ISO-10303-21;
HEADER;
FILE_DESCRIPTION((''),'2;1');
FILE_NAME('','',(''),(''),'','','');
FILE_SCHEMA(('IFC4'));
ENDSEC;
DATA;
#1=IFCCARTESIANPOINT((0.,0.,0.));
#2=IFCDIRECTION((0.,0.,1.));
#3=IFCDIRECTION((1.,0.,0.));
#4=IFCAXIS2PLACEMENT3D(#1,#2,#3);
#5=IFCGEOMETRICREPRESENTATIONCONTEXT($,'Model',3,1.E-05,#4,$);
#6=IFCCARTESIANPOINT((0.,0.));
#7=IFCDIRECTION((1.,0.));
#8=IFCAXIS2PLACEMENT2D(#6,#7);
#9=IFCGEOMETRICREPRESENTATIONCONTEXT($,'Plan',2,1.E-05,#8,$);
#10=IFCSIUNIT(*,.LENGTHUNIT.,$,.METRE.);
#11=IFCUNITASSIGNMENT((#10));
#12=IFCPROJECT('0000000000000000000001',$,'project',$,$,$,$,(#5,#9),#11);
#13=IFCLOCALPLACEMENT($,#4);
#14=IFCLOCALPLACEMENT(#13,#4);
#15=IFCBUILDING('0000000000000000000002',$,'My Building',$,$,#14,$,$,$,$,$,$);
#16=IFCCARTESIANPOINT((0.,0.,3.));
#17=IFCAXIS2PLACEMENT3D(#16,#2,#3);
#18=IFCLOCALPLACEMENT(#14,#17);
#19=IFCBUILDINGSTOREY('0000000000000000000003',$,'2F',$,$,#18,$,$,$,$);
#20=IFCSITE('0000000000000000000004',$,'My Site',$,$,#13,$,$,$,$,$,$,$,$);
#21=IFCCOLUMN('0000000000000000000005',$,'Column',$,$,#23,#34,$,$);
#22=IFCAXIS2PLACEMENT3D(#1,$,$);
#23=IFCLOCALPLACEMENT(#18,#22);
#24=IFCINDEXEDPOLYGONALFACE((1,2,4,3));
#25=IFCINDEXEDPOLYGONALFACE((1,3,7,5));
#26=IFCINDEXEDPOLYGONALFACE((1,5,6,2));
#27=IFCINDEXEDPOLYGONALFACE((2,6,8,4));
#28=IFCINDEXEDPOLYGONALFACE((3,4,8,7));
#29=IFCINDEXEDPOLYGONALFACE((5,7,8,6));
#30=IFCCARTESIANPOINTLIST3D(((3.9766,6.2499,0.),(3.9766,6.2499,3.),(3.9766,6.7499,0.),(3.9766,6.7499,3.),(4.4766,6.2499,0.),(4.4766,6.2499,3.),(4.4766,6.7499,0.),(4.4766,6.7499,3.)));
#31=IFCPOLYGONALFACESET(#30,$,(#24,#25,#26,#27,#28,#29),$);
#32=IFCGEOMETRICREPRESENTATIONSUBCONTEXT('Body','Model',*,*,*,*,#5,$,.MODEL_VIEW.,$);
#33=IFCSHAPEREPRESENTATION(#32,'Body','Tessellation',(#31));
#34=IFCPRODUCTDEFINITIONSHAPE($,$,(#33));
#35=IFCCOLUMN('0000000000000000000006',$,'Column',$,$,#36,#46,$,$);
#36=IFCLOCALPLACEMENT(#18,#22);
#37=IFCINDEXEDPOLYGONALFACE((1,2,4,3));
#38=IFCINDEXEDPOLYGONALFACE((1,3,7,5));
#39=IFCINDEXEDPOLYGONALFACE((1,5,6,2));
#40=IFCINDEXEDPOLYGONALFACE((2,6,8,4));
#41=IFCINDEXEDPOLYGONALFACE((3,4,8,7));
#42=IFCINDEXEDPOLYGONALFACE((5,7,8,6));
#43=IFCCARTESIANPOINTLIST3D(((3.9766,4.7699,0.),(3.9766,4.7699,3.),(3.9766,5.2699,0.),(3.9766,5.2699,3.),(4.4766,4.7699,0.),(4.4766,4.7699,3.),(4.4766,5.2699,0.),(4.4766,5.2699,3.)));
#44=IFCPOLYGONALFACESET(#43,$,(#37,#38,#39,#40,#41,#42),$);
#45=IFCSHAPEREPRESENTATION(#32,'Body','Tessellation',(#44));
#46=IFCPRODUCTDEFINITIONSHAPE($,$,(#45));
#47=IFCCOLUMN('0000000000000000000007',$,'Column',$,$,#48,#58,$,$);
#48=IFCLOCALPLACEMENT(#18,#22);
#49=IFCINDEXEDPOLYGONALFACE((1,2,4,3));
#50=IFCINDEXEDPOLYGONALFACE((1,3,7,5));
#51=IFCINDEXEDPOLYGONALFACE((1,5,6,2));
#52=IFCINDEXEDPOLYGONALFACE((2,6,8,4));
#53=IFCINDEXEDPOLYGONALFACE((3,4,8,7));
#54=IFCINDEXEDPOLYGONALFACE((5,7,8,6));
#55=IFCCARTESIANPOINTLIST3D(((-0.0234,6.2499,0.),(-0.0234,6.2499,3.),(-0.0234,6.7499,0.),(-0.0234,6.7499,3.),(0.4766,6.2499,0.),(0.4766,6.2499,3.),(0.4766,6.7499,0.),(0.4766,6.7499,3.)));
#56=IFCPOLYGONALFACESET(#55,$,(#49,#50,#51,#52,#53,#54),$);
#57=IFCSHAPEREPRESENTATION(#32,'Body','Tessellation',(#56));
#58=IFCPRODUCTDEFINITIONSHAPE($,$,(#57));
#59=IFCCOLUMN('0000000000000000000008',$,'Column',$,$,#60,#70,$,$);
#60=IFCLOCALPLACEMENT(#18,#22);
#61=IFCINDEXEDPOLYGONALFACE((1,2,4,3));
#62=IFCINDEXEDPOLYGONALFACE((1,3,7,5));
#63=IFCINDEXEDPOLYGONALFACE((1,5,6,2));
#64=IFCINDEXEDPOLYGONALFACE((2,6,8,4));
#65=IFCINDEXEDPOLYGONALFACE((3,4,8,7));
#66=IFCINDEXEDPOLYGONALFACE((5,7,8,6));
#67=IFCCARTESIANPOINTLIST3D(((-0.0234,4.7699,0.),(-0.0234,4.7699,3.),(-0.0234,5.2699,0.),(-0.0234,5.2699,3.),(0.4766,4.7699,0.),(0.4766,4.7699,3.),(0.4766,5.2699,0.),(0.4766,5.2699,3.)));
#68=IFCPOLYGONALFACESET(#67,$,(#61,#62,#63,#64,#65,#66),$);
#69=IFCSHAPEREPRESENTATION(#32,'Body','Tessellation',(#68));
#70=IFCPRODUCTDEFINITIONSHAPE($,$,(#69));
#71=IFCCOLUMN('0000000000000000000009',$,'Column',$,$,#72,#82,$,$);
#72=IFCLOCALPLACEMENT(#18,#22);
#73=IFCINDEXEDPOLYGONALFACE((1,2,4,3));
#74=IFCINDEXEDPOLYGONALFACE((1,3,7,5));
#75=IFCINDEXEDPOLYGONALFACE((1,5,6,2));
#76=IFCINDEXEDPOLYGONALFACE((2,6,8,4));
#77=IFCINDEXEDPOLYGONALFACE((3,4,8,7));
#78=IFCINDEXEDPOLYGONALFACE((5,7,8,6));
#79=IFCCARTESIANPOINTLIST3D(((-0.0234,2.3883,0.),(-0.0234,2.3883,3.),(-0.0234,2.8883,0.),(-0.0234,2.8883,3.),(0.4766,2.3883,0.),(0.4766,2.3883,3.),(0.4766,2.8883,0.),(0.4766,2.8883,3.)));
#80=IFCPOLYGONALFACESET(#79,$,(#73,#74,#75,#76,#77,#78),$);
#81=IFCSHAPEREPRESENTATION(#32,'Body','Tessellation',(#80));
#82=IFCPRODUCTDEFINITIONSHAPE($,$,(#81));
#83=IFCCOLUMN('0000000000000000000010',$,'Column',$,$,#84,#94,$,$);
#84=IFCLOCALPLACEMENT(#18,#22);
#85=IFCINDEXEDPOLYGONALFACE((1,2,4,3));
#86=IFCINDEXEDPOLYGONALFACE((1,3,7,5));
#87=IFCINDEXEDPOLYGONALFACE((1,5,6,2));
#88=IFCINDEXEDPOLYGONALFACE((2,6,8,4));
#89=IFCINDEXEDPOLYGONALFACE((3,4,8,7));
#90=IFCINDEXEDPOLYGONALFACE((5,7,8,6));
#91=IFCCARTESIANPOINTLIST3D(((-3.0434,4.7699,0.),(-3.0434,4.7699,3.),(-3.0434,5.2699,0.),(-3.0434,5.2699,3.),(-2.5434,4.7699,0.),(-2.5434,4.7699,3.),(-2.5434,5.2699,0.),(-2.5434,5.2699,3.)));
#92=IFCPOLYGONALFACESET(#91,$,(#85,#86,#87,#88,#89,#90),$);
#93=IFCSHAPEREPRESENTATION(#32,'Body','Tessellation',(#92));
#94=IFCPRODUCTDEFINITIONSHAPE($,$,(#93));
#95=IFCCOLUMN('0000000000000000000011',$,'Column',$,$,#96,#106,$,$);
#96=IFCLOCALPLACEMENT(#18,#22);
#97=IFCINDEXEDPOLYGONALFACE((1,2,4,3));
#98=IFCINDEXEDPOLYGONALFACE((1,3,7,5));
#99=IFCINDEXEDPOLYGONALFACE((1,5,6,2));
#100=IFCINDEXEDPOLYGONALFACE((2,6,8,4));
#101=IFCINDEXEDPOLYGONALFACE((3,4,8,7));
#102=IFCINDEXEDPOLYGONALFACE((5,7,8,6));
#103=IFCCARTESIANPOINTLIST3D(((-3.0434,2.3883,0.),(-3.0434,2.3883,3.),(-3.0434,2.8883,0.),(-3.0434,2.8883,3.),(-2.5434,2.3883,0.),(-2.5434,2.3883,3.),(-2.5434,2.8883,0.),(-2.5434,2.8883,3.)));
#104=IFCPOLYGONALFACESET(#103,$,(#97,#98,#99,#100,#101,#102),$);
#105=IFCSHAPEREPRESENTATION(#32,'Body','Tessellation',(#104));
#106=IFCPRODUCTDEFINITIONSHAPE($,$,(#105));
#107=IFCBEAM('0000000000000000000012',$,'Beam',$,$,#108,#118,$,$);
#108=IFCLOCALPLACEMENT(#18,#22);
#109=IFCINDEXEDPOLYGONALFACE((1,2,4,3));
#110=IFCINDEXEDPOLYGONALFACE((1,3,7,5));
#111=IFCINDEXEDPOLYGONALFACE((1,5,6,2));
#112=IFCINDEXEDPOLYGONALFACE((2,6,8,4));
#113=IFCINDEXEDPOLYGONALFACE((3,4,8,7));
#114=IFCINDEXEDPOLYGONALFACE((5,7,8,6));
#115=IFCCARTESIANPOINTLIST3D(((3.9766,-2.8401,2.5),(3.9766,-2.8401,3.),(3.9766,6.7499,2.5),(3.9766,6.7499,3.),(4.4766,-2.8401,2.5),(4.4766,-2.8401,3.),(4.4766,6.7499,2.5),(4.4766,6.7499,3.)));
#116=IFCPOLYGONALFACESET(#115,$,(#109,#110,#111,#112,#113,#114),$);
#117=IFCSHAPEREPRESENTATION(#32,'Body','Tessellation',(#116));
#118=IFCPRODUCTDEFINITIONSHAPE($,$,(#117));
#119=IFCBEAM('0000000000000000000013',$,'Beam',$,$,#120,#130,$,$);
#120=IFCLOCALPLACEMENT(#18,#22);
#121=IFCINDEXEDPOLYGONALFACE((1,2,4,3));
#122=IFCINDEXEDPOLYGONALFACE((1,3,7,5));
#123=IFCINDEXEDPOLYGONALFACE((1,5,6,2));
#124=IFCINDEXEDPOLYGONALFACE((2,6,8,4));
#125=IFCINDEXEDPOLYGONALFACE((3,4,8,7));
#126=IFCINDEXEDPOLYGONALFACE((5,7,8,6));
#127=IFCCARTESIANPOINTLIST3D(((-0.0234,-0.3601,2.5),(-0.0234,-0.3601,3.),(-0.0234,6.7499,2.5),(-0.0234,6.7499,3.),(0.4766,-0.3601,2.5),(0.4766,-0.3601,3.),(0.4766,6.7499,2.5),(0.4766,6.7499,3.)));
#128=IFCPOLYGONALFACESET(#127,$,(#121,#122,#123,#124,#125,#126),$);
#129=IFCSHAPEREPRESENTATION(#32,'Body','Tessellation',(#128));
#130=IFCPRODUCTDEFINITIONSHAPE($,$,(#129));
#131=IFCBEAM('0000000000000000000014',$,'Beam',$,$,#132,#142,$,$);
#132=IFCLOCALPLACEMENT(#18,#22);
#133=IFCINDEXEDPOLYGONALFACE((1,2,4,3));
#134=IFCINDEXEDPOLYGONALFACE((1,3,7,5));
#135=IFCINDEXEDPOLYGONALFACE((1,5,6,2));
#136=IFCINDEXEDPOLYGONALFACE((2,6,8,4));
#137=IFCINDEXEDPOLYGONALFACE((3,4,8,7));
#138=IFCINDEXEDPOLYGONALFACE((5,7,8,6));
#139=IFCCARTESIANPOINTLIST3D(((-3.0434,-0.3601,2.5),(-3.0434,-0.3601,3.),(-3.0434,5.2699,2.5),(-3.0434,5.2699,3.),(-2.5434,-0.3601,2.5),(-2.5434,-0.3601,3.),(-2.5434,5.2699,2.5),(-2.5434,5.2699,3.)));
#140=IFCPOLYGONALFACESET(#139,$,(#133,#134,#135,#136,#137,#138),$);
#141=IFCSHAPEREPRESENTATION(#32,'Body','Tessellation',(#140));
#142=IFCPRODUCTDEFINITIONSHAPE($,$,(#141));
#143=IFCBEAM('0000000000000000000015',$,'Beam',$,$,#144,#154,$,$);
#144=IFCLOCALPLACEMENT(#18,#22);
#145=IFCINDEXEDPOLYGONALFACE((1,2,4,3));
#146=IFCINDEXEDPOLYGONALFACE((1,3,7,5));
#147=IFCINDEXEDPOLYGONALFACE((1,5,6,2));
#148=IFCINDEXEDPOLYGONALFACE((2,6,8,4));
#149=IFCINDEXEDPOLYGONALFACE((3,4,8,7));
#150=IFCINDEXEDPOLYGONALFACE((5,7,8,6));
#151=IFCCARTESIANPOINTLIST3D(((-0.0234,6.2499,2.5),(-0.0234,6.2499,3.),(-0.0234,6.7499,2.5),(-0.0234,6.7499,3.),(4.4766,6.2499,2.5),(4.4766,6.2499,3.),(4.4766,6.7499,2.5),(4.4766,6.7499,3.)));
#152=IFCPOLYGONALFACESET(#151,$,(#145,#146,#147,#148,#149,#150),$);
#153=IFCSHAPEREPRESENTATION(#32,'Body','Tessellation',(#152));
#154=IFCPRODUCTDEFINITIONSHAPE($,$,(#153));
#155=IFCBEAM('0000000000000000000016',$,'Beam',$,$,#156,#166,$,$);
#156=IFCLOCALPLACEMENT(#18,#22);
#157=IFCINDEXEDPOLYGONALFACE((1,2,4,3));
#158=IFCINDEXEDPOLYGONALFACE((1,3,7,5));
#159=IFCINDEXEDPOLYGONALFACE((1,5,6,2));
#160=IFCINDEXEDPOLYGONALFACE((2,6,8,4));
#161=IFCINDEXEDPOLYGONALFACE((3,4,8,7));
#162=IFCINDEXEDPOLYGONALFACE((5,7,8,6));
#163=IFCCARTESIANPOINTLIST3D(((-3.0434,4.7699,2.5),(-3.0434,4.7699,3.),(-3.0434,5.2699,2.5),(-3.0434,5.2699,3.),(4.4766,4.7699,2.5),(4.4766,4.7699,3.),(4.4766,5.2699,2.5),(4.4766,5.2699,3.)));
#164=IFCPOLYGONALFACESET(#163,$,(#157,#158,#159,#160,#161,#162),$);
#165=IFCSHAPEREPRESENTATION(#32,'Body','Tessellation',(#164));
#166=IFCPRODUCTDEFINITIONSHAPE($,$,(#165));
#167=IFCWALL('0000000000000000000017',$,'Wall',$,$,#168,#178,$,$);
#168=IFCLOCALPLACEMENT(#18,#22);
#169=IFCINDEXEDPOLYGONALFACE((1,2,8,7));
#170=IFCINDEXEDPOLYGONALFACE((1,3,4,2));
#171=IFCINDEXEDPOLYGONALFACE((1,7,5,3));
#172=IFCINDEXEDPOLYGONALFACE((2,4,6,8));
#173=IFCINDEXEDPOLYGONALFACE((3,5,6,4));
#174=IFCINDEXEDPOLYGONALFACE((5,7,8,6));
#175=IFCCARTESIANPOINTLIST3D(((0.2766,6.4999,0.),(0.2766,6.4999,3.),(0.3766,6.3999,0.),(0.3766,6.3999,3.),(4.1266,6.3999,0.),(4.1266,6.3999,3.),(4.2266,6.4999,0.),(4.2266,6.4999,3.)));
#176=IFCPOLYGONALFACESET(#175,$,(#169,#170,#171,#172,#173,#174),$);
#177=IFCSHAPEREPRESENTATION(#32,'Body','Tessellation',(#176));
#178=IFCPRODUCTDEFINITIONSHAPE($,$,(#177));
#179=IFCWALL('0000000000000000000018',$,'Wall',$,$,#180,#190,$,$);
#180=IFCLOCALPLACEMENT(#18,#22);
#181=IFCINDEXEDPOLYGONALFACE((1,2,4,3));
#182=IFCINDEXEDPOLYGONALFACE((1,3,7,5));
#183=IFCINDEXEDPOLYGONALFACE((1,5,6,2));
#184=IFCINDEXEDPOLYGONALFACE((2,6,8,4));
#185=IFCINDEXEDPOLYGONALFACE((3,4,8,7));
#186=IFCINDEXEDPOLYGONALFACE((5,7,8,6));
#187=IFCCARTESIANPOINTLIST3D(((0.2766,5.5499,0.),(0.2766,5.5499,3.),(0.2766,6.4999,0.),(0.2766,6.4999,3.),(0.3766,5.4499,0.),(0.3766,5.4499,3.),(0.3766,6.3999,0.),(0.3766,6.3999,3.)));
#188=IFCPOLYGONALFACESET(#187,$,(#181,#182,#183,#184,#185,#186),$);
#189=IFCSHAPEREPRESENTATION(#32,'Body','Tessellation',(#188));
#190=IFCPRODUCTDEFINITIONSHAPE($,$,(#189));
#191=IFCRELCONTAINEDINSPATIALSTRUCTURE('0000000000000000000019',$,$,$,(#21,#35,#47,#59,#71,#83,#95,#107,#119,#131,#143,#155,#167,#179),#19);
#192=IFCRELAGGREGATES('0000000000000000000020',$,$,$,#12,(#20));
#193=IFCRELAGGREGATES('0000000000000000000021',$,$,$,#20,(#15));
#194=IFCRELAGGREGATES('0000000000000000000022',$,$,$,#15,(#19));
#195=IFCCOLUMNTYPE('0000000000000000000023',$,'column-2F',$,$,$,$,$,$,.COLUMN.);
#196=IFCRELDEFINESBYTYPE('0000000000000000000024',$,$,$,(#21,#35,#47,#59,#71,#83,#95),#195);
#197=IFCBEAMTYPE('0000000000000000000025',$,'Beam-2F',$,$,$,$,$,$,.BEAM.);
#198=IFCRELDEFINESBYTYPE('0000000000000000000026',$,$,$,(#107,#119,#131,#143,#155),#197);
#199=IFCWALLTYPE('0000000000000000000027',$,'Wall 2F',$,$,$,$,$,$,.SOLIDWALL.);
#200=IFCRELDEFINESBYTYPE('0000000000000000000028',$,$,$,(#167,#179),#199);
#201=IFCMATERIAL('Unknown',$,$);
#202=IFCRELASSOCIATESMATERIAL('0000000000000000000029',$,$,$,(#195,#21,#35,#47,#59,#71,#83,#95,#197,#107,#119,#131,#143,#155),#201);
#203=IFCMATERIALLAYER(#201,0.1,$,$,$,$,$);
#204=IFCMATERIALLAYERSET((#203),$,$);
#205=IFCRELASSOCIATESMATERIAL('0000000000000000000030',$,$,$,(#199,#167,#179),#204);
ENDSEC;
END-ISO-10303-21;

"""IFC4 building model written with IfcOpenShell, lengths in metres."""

from ifc_helpers import new_model, si_unit, frame, origin_with_axes, origin_2d_with_axis, place, context, subcontext, project, spatial, line, indexed_curve, rectangle, outline, extrude, material, layer, layer_set, layer_usage, material_profile, profile_set, profile_usage, type_object, element, save


model = new_model("IFC4")

# Units and contexts
model_context = context("Model", 3, precision=1e-05, world=origin_with_axes())
plan_context = context("Plan", 2, precision=1e-05, world=origin_2d_with_axis())
body_context_1 = subcontext(model_context, "Body", "Model", "MODEL_VIEW")
ifc_project = project(units=[si_unit("LENGTHUNIT", "METRE")], contexts=[model_context, plan_context])

# Site, building, storey
site_placement = place(None, origin_with_axes())
site = spatial("IfcSite", under=ifc_project, at=site_placement, Name="My Site")
building_placement = place(site_placement, origin_with_axes())
building = spatial("IfcBuilding", under=site, at=building_placement, Name="My Building")
storey_placement = place(building_placement, frame((0.0, 0.0, 3.0), z_axis=(0.0, 0.0, 1.0), x_axis=(1.0, 0.0, 0.0)))
storey = spatial("IfcBuildingStorey", under=building, at=storey_placement, Name="2F")

# Columns
ifc_material = material(Name="Unknown")
ifc_material_profile_1 = material_profile(ifc_material, rectangle(XDim=0.5, YDim=0.5))
ifc_profile_set_1 = profile_set([ifc_material_profile_1])
ifc_profile_usage_1 = profile_usage(ifc_profile_set_1, cardinal=7)
column_type = type_object("IfcColumnType", Name="column-2F", PredefinedType="COLUMN", material=ifc_profile_set_1)
column_1_placement = place(storey_placement, frame((4.4766, 6.7499, 0.0), z_axis=(0.0, 0.0, 1.0), x_axis=(1.0, 0.0, 0.0)))
element("IfcColumn", 1, at=column_1_placement, inside=storey, type_object=column_type, material=ifc_profile_usage_1, Name="Column", context=body_context_1, shape_type="SweptSolid", body=[
    extrude(rectangle(XDim=0.5, YDim=0.5), frame((-0.25, -0.25, 0.0), z_axis=(0.0, 0.0, 1.0), x_axis=(1.0, 0.0, 0.0)), (0.0, 0.0, 1.0), 3.0),
])
ifc_profile_usage_2 = profile_usage(ifc_profile_set_1, cardinal=7)
column_2_placement = place(storey_placement, frame((4.4766, 5.2699, 0.0), z_axis=(0.0, 0.0, 1.0), x_axis=(1.0, 0.0, 0.0)))
element("IfcColumn", 2, at=column_2_placement, inside=storey, type_object=column_type, material=ifc_profile_usage_2, Name="Column", context=body_context_1, shape_type="SweptSolid", body=[
    extrude(rectangle(XDim=0.5, YDim=0.5), frame((-0.25, -0.25, 0.0), z_axis=(0.0, 0.0, 1.0), x_axis=(1.0, 0.0, 0.0)), (0.0, 0.0, 1.0), 3.0),
])
ifc_profile_usage_3 = profile_usage(ifc_profile_set_1, cardinal=7)
column_3_placement = place(storey_placement, frame((0.4766, 6.7499, 0.0), z_axis=(0.0, 0.0, 1.0), x_axis=(1.0, 0.0, 0.0)))
element("IfcColumn", 3, at=column_3_placement, inside=storey, type_object=column_type, material=ifc_profile_usage_3, Name="Column", context=body_context_1, shape_type="SweptSolid", body=[
    extrude(rectangle(XDim=0.5, YDim=0.5), frame((-0.25, -0.25, 0.0), z_axis=(0.0, 0.0, 1.0), x_axis=(1.0, 0.0, 0.0)), (0.0, 0.0, 1.0), 3.0),
])
ifc_profile_usage_4 = profile_usage(ifc_profile_set_1, cardinal=7)
column_4_placement = place(storey_placement, frame((0.4766, 5.2699, 0.0), z_axis=(0.0, 0.0, 1.0), x_axis=(1.0, 0.0, 0.0)))
element("IfcColumn", 4, at=column_4_placement, inside=storey, type_object=column_type, material=ifc_profile_usage_4, Name="Column", context=body_context_1, shape_type="SweptSolid", body=[
    extrude(rectangle(XDim=0.5, YDim=0.5), frame((-0.25, -0.25, 0.0), z_axis=(0.0, 0.0, 1.0), x_axis=(1.0, 0.0, 0.0)), (0.0, 0.0, 1.0), 3.0),
])
ifc_profile_usage_5 = profile_usage(ifc_profile_set_1, cardinal=7)
column_5_placement = place(storey_placement, frame((0.4766, 2.8883, 0.0), z_axis=(0.0, 0.0, 1.0), x_axis=(1.0, 0.0, 0.0)))
element("IfcColumn", 5, at=column_5_placement, inside=storey, type_object=column_type, material=ifc_profile_usage_5, Name="Column", context=body_context_1, shape_type="SweptSolid", body=[
    extrude(rectangle(XDim=0.5, YDim=0.5), frame((-0.25, -0.25, 0.0), z_axis=(0.0, 0.0, 1.0), x_axis=(1.0, 0.0, 0.0)), (0.0, 0.0, 1.0), 3.0),
])
ifc_profile_usage_6 = profile_usage(ifc_profile_set_1, cardinal=7)
column_6_placement = place(storey_placement, frame((-2.5434, 5.2699, 0.0), z_axis=(0.0, 0.0, 1.0), x_axis=(1.0, 0.0, 0.0)))
element("IfcColumn", 6, at=column_6_placement, inside=storey, type_object=column_type, material=ifc_profile_usage_6, Name="Column", context=body_context_1, shape_type="SweptSolid", body=[
    extrude(rectangle(XDim=0.5, YDim=0.5), frame((-0.25, -0.25, 0.0), z_axis=(0.0, 0.0, 1.0), x_axis=(1.0, 0.0, 0.0)), (0.0, 0.0, 1.0), 3.0),
])
ifc_profile_usage_7 = profile_usage(ifc_profile_set_1, cardinal=7)
column_7_placement = place(storey_placement, frame((-2.5434, 2.8883, 0.0), z_axis=(0.0, 0.0, 1.0), x_axis=(1.0, 0.0, 0.0)))
element("IfcColumn", 7, at=column_7_placement, inside=storey, type_object=column_type, material=ifc_profile_usage_7, Name="Column", context=body_context_1, shape_type="SweptSolid", body=[
    extrude(rectangle(XDim=0.5, YDim=0.5), frame((-0.25, -0.25, 0.0), z_axis=(0.0, 0.0, 1.0), x_axis=(1.0, 0.0, 0.0)), (0.0, 0.0, 1.0), 3.0),
])

# Beams
ifc_material_profile_2 = material_profile(ifc_material, rectangle(XDim=0.5, YDim=0.5))
ifc_profile_set_2 = profile_set([ifc_material_profile_2])
ifc_profile_usage_8 = profile_usage(ifc_profile_set_2, cardinal=7)
beam_type = type_object("IfcBeamType", Name="Beam-2F", PredefinedType="BEAM", material=ifc_profile_set_2)
beam_1_placement = place(storey_placement, frame((4.4766, 6.7499, 3.0), z_axis=(0.0, -1.0, 0.0), x_axis=(1.0, 0.0, 0.0)))
element("IfcBeam", 8, at=beam_1_placement, inside=storey, type_object=beam_type, material=ifc_profile_usage_8, Name="Beam", context=body_context_1, shape_type="SweptSolid", body=[
    extrude(rectangle(XDim=0.5, YDim=0.5), frame((-0.25, -0.25, 0.0), z_axis=(0.0, 0.0, 1.0), x_axis=(1.0, 0.0, 0.0)), (0.0, 0.0, 1.0), 9.59),
])
ifc_profile_usage_9 = profile_usage(ifc_profile_set_2, cardinal=7)
beam_2_placement = place(storey_placement, frame((0.4766, 6.7499, 3.0), z_axis=(0.0, -1.0, 0.0), x_axis=(1.0, 0.0, 0.0)))
element("IfcBeam", 9, at=beam_2_placement, inside=storey, type_object=beam_type, material=ifc_profile_usage_9, Name="Beam", context=body_context_1, shape_type="SweptSolid", body=[
    extrude(rectangle(XDim=0.5, YDim=0.5), frame((-0.25, -0.25, 0.0), z_axis=(0.0, 0.0, 1.0), x_axis=(1.0, 0.0, 0.0)), (0.0, 0.0, 1.0), 7.11),
])
ifc_profile_usage_10 = profile_usage(ifc_profile_set_2, cardinal=7)
beam_3_placement = place(storey_placement, frame((-2.5434, 5.2699, 3.0), z_axis=(0.0, -1.0, 0.0), x_axis=(1.0, 0.0, 0.0)))
element("IfcBeam", 10, at=beam_3_placement, inside=storey, type_object=beam_type, material=ifc_profile_usage_10, Name="Beam", context=body_context_1, shape_type="SweptSolid", body=[
    extrude(rectangle(XDim=0.5, YDim=0.5), frame((-0.25, -0.25, 0.0), z_axis=(0.0, 0.0, 1.0), x_axis=(1.0, 0.0, 0.0)), (0.0, 0.0, 1.0), 5.63),
])
ifc_profile_usage_11 = profile_usage(ifc_profile_set_2, cardinal=7)
beam_4_placement = place(storey_placement, frame((4.4766, 6.2499, 3.0), z_axis=(-1.0, 0.0, 0.0), x_axis=(0.0, -1.0, 0.0)))
element("IfcBeam", 11, at=beam_4_placement, inside=storey, type_object=beam_type, material=ifc_profile_usage_11, Name="Beam", context=body_context_1, shape_type="SweptSolid", body=[
    extrude(rectangle(XDim=0.5, YDim=0.5), frame((-0.25, -0.25, 0.0), z_axis=(0.0, 0.0, 1.0), x_axis=(1.0, 0.0, 0.0)), (0.0, 0.0, 1.0), 4.5),
])
ifc_profile_usage_12 = profile_usage(ifc_profile_set_2, cardinal=7)
beam_5_placement = place(storey_placement, frame((4.4766, 4.7699, 3.0), z_axis=(-1.0, 0.0, 0.0), x_axis=(0.0, -1.0, 0.0)))
element("IfcBeam", 12, at=beam_5_placement, inside=storey, type_object=beam_type, material=ifc_profile_usage_12, Name="Beam", context=body_context_1, shape_type="SweptSolid", body=[
    extrude(rectangle(XDim=0.5, YDim=0.5), frame((-0.25, -0.25, 0.0), z_axis=(0.0, 0.0, 1.0), x_axis=(1.0, 0.0, 0.0)), (0.0, 0.0, 1.0), 7.52),
])

# Walls
ifc_layer = layer(ifc_material, 0.1)
ifc_layer_set = layer_set([ifc_layer])
ifc_layer_usage_1 = layer_usage(ifc_layer_set, "AXIS2", "POSITIVE", 0.0)
wall_type = type_object("IfcWallType", Name="Wall 2F", PredefinedType="SOLIDWALL", material=ifc_layer_set)
wall_1_placement = place(storey_placement, frame((4.2266, 6.4999, 0.0), z_axis=(0.0, 0.0, 1.0), x_axis=(-1.0, 0.0, 0.0)))
element("IfcWall", 13, at=wall_1_placement, inside=storey, type_object=wall_type, material=ifc_layer_usage_1, Name="Wall", context=body_context_1, shape_type="SweptSolid", body=[
    extrude(outline(indexed_curve([(0.0, 0.0), (0.1, 0.1), (3.85, 0.1), (3.95, 0.0)], segments=[line(1, 2, 3, 4, 1)])), origin_with_axes(), (0.0, 0.0, 1.0), 3.0),
])
ifc_layer_usage_2 = layer_usage(ifc_layer_set, "AXIS2", "POSITIVE", 0.0)
wall_2_placement = place(storey_placement, frame((0.2766, 6.4999, 0.0), z_axis=(0.0, 0.0, 1.0), x_axis=(0.0, -1.0, 0.0)))
element("IfcWall", 14, at=wall_2_placement, inside=storey, type_object=wall_type, material=ifc_layer_usage_2, Name="Wall", context=body_context_1, shape_type="SweptSolid", body=[
    extrude(outline(indexed_curve([(0.0, 0.0), (0.1, 0.1), (1.05, 0.1), (0.95, 0.0)], segments=[line(1, 2, 3, 4, 1)])), origin_with_axes(), (0.0, 0.0, 1.0), 3.0),
])

save(model, "model.ifc")
